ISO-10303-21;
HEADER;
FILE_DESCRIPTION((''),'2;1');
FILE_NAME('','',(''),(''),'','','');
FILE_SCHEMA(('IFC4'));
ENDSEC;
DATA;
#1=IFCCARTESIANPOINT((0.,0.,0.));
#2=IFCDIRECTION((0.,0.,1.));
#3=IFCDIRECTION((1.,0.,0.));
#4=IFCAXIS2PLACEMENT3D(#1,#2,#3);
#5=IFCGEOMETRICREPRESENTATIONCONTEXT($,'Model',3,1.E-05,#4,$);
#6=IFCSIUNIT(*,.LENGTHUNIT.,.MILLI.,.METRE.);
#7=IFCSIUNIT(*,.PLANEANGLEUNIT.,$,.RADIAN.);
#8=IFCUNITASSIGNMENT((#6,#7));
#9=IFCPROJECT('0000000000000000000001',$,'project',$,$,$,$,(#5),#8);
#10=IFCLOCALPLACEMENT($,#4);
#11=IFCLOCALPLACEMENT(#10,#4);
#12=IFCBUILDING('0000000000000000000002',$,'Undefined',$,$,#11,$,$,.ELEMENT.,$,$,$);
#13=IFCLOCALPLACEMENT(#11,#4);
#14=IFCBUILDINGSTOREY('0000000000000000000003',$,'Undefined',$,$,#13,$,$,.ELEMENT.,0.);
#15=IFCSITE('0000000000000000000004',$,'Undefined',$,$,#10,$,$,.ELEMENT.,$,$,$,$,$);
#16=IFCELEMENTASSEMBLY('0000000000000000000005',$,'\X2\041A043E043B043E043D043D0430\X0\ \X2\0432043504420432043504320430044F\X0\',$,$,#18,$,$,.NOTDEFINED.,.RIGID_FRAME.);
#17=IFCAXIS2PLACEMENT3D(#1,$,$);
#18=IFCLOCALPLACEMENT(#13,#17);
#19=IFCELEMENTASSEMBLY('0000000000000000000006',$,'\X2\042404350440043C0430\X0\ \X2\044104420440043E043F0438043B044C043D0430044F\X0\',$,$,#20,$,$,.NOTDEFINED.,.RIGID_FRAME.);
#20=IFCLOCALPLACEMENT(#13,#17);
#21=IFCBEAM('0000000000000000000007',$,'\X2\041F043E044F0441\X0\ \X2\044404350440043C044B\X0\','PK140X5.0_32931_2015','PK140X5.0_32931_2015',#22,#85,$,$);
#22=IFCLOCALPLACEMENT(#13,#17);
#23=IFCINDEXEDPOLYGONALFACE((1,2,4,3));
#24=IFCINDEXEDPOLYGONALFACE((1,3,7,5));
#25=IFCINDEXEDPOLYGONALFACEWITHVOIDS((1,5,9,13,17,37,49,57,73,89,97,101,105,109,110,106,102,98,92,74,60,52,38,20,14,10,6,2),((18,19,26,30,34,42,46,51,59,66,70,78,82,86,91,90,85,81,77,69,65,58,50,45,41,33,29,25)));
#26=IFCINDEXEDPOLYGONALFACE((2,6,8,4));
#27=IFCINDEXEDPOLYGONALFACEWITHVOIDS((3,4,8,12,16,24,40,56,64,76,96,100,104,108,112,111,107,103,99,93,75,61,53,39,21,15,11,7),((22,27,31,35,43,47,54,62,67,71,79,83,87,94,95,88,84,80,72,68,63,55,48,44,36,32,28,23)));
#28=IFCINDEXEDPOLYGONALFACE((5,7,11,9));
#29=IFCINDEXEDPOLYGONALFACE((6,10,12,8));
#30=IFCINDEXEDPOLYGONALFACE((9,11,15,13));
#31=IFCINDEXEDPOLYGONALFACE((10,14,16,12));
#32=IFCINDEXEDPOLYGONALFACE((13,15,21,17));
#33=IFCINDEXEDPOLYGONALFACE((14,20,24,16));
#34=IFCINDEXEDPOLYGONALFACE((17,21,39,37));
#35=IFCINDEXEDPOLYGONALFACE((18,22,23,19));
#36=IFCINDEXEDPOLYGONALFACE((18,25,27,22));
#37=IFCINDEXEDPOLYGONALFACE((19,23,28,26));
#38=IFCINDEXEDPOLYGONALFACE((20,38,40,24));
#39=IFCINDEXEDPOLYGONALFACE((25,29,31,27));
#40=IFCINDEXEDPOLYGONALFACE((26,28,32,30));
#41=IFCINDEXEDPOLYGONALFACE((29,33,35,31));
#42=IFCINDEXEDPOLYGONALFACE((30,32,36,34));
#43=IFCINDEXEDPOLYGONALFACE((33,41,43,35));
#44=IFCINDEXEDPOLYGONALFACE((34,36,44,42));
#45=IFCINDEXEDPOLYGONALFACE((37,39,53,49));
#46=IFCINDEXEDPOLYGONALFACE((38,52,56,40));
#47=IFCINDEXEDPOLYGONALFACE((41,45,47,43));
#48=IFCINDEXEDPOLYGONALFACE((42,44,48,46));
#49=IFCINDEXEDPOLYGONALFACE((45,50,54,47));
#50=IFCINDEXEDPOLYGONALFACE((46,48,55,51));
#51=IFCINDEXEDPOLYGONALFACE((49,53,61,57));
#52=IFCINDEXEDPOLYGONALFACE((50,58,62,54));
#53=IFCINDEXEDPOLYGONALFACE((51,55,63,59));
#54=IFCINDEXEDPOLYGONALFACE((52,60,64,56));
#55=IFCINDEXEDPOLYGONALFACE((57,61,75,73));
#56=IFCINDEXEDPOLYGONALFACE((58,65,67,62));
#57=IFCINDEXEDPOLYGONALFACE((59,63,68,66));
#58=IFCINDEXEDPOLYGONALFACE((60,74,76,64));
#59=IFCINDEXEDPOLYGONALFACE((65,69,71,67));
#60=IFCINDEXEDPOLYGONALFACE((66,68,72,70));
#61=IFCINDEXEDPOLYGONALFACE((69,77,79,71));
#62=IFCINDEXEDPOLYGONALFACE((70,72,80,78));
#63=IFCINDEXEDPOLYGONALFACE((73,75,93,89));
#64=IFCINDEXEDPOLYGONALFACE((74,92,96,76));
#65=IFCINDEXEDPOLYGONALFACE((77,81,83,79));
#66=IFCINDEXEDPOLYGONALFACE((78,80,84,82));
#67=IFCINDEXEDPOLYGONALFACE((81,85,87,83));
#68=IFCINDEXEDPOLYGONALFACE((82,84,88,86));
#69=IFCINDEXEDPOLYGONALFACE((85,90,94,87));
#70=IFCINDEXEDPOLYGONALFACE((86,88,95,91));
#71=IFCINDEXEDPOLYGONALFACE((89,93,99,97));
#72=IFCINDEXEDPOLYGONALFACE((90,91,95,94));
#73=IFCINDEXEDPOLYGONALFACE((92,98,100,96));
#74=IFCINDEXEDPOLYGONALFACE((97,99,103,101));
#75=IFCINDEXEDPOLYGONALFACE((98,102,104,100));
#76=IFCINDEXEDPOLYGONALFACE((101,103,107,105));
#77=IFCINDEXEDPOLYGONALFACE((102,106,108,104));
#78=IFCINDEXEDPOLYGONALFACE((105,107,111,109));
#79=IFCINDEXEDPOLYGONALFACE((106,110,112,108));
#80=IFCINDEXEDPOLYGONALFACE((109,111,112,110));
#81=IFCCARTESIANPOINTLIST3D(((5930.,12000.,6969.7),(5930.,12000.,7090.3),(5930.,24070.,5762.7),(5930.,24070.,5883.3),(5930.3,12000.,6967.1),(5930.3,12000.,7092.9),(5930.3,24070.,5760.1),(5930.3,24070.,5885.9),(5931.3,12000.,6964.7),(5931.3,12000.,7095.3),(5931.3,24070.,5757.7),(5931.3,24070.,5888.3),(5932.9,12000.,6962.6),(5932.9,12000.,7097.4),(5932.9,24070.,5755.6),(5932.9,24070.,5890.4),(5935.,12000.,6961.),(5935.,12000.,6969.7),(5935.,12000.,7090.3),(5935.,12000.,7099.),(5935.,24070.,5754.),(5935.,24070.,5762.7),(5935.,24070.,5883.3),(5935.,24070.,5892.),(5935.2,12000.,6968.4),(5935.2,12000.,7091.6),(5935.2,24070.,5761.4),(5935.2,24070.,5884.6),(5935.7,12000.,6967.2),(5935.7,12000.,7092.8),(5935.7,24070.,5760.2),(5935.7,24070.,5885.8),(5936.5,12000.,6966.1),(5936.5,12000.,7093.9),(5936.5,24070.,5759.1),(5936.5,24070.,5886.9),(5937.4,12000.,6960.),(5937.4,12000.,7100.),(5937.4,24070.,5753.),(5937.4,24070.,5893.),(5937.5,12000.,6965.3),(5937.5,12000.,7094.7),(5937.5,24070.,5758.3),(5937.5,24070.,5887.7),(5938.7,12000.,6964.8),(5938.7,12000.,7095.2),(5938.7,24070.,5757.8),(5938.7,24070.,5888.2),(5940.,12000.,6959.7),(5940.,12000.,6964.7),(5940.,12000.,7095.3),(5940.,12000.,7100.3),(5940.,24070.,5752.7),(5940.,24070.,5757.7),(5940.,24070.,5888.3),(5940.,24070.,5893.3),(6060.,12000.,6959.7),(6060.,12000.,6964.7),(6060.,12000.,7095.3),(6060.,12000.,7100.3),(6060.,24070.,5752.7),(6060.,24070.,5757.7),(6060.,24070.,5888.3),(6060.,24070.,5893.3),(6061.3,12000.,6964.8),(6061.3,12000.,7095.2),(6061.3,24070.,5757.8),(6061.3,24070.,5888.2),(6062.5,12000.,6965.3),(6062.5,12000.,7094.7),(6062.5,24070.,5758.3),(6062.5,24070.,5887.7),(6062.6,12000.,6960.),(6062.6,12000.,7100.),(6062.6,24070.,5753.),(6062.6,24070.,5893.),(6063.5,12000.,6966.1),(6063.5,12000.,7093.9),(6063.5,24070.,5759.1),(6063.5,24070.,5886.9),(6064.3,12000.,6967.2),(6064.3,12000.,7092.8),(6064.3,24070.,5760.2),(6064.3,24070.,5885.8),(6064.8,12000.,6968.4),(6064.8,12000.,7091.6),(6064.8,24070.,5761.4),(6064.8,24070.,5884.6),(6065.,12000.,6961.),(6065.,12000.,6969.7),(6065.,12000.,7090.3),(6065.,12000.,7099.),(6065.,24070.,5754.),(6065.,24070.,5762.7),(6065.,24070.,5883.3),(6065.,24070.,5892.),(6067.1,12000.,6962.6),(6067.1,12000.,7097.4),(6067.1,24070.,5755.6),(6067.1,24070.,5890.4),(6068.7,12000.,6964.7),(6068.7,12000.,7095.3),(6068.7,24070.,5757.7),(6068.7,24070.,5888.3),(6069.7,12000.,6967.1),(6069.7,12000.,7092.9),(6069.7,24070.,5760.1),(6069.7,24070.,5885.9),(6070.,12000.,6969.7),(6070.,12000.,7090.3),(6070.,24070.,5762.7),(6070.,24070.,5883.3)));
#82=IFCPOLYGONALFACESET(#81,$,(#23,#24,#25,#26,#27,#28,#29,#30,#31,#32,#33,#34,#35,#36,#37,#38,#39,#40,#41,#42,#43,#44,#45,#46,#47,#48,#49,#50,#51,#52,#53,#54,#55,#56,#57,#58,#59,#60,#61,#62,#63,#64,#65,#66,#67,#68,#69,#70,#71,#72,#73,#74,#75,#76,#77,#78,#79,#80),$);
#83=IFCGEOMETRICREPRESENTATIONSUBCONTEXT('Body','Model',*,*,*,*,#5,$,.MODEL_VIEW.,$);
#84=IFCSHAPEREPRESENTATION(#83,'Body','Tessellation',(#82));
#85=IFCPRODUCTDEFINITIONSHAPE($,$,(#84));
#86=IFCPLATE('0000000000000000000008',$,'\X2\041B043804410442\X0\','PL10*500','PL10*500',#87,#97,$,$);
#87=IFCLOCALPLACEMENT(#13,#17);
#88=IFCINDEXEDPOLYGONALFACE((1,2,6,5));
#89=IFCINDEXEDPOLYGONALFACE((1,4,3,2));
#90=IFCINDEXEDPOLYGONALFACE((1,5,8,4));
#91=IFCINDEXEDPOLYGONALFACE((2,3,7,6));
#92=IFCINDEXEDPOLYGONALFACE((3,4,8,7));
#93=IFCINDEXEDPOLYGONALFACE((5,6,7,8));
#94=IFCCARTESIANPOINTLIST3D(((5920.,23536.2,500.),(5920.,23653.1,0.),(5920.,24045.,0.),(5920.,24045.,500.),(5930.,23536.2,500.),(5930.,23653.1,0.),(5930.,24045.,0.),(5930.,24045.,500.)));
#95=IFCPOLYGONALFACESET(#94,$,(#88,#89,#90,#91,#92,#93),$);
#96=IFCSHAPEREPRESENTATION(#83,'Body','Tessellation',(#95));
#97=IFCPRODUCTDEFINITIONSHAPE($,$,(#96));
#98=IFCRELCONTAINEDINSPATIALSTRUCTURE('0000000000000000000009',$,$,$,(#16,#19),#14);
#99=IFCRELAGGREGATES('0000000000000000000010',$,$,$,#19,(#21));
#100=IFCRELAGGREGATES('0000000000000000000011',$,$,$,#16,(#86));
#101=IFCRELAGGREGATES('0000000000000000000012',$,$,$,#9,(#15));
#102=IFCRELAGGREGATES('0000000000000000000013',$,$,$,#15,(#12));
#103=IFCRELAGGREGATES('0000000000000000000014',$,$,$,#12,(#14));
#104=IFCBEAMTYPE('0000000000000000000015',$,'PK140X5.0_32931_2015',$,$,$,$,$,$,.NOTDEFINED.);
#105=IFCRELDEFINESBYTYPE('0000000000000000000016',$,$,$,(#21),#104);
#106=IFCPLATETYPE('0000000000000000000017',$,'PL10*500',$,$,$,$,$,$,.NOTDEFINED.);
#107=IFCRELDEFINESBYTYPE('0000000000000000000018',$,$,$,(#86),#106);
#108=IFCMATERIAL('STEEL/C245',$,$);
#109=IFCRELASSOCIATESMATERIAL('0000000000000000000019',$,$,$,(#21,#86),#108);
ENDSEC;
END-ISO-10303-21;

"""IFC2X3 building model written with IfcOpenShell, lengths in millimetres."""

from ifc_helpers import new_model, si_unit, frame, origin_with_axes, origin_2d_with_axis, place, context, subcontext, project, spatial, polyline, hollow_rectangle, outline, extrude, clip, halfspace, material, type_object, element, aggregate, save


model = new_model("IFC2X3")

# Units and contexts
model_context = context("Model", 3, precision=1e-05, world=origin_with_axes())
body_context = subcontext(model_context, "Body", "Model", "MODEL_VIEW")
ifc_project = project(units=[si_unit("LENGTHUNIT", "METRE", prefix="MILLI"), si_unit("PLANEANGLEUNIT", "RADIAN")], contexts=[model_context])

# Site, building, storey
site_placement = place(None, origin_with_axes())
site = spatial("IfcSite", under=ifc_project, at=site_placement, Name="Undefined", CompositionType="ELEMENT")
building_placement = place(site_placement, origin_with_axes())
building = spatial("IfcBuilding", under=site, at=building_placement, Name="Undefined", CompositionType="ELEMENT")
storey_placement = place(building_placement, origin_with_axes())
storey = spatial("IfcBuildingStorey", under=building, at=storey_placement, Name="Undefined", CompositionType="ELEMENT", Elevation=0.0)

# Shared definitions
ifc_material_1 = material(Name="STEEL/C245")

# Element assembly
assembly_1_placement = place(storey_placement, origin_with_axes())
assembly_1 = element("IfcElementAssembly", 1, at=assembly_1_placement, inside=storey, Name="Колонна ветвевая", AssemblyPlace="NOTDEFINED", PredefinedType="RIGID_FRAME")

# Element assembly
assembly_2_placement = place(storey_placement, origin_with_axes())
assembly_2 = element("IfcElementAssembly", 2, at=assembly_2_placement, inside=storey, Name="Ферма стропильная", AssemblyPlace="NOTDEFINED", PredefinedType="RIGID_FRAME")

# Beam
beam_type_1 = type_object("IfcBeamType", Name="PK140X5.0_32931_2015", PredefinedType="NOTDEFINED")
beam_1_placement = place(assembly_2_placement, frame((6000.0, 24000.0, 5830.0), z_axis=(0.0, 0.099504, 0.995037), x_axis=(0.0, -0.995037, 0.099504)))
beam_1 = element("IfcBeam", 3, at=beam_1_placement, type_object=beam_type_1, material=ifc_material_1, Name="Пояс фермы", Description="PK140X5.0_32931_2015", ObjectType="PK140X5.0_32931_2015", context=body_context, shape_type="Clipping", body=[
    clip(clip(extrude(hollow_rectangle(XDim=140.0, YDim=140.0, WallThickness=5.0, InnerFilletRadius=5.0, OuterFilletRadius=10.0, at=origin_2d_with_axis()), frame((12074.0, 0.0, 0.0), z_axis=(-1.0, 0.0, 0.0), x_axis=(0.0, -1.0, 0.0)), (0.0, 0.0, 1.0), 12158.5), halfspace(frame((12239.3, 0.0, 1794.2), z_axis=(0.995037, 0.0, -0.099504), x_axis=(0.099504, 0.0, 0.995037)), False)), halfspace(frame((-65.6, 0.0, 47.4), z_axis=(0.995037, 0.0, -0.099504), x_axis=(0.099504, 0.0, 0.995037)), True)),
])
aggregate(assembly_2, [beam_1])

# Plate
plate_type = type_object("IfcPlateType", Name="PL10*500", PredefinedType="NOTDEFINED")
plate_placement = place(assembly_1_placement, frame((5925.0, 24045.0, 500.0), z_axis=(-1.0, 0.0, 0.0), x_axis=(0.0, 0.0, -1.0)))
plate = element("IfcPlate", 4, at=plate_placement, type_object=plate_type, material=ifc_material_1, Name="Лист", Description="PL10*500", ObjectType="PL10*500", context=body_context, shape_type="SweptSolid", body=[
    extrude(outline(polyline([(0.0, 0.0), (500.0, 0.0), (500.0, 391.9), (0.0, 508.8), (0.0, 0.0)])), frame((0.0, 0.0, -5.0), z_axis=(0.0, 0.0, 1.0), x_axis=(1.0, 0.0, 0.0)), (0.0, 0.0, 1.0), 10.0),
])
aggregate(assembly_1, [plate])

save(model, "model.ifc")
